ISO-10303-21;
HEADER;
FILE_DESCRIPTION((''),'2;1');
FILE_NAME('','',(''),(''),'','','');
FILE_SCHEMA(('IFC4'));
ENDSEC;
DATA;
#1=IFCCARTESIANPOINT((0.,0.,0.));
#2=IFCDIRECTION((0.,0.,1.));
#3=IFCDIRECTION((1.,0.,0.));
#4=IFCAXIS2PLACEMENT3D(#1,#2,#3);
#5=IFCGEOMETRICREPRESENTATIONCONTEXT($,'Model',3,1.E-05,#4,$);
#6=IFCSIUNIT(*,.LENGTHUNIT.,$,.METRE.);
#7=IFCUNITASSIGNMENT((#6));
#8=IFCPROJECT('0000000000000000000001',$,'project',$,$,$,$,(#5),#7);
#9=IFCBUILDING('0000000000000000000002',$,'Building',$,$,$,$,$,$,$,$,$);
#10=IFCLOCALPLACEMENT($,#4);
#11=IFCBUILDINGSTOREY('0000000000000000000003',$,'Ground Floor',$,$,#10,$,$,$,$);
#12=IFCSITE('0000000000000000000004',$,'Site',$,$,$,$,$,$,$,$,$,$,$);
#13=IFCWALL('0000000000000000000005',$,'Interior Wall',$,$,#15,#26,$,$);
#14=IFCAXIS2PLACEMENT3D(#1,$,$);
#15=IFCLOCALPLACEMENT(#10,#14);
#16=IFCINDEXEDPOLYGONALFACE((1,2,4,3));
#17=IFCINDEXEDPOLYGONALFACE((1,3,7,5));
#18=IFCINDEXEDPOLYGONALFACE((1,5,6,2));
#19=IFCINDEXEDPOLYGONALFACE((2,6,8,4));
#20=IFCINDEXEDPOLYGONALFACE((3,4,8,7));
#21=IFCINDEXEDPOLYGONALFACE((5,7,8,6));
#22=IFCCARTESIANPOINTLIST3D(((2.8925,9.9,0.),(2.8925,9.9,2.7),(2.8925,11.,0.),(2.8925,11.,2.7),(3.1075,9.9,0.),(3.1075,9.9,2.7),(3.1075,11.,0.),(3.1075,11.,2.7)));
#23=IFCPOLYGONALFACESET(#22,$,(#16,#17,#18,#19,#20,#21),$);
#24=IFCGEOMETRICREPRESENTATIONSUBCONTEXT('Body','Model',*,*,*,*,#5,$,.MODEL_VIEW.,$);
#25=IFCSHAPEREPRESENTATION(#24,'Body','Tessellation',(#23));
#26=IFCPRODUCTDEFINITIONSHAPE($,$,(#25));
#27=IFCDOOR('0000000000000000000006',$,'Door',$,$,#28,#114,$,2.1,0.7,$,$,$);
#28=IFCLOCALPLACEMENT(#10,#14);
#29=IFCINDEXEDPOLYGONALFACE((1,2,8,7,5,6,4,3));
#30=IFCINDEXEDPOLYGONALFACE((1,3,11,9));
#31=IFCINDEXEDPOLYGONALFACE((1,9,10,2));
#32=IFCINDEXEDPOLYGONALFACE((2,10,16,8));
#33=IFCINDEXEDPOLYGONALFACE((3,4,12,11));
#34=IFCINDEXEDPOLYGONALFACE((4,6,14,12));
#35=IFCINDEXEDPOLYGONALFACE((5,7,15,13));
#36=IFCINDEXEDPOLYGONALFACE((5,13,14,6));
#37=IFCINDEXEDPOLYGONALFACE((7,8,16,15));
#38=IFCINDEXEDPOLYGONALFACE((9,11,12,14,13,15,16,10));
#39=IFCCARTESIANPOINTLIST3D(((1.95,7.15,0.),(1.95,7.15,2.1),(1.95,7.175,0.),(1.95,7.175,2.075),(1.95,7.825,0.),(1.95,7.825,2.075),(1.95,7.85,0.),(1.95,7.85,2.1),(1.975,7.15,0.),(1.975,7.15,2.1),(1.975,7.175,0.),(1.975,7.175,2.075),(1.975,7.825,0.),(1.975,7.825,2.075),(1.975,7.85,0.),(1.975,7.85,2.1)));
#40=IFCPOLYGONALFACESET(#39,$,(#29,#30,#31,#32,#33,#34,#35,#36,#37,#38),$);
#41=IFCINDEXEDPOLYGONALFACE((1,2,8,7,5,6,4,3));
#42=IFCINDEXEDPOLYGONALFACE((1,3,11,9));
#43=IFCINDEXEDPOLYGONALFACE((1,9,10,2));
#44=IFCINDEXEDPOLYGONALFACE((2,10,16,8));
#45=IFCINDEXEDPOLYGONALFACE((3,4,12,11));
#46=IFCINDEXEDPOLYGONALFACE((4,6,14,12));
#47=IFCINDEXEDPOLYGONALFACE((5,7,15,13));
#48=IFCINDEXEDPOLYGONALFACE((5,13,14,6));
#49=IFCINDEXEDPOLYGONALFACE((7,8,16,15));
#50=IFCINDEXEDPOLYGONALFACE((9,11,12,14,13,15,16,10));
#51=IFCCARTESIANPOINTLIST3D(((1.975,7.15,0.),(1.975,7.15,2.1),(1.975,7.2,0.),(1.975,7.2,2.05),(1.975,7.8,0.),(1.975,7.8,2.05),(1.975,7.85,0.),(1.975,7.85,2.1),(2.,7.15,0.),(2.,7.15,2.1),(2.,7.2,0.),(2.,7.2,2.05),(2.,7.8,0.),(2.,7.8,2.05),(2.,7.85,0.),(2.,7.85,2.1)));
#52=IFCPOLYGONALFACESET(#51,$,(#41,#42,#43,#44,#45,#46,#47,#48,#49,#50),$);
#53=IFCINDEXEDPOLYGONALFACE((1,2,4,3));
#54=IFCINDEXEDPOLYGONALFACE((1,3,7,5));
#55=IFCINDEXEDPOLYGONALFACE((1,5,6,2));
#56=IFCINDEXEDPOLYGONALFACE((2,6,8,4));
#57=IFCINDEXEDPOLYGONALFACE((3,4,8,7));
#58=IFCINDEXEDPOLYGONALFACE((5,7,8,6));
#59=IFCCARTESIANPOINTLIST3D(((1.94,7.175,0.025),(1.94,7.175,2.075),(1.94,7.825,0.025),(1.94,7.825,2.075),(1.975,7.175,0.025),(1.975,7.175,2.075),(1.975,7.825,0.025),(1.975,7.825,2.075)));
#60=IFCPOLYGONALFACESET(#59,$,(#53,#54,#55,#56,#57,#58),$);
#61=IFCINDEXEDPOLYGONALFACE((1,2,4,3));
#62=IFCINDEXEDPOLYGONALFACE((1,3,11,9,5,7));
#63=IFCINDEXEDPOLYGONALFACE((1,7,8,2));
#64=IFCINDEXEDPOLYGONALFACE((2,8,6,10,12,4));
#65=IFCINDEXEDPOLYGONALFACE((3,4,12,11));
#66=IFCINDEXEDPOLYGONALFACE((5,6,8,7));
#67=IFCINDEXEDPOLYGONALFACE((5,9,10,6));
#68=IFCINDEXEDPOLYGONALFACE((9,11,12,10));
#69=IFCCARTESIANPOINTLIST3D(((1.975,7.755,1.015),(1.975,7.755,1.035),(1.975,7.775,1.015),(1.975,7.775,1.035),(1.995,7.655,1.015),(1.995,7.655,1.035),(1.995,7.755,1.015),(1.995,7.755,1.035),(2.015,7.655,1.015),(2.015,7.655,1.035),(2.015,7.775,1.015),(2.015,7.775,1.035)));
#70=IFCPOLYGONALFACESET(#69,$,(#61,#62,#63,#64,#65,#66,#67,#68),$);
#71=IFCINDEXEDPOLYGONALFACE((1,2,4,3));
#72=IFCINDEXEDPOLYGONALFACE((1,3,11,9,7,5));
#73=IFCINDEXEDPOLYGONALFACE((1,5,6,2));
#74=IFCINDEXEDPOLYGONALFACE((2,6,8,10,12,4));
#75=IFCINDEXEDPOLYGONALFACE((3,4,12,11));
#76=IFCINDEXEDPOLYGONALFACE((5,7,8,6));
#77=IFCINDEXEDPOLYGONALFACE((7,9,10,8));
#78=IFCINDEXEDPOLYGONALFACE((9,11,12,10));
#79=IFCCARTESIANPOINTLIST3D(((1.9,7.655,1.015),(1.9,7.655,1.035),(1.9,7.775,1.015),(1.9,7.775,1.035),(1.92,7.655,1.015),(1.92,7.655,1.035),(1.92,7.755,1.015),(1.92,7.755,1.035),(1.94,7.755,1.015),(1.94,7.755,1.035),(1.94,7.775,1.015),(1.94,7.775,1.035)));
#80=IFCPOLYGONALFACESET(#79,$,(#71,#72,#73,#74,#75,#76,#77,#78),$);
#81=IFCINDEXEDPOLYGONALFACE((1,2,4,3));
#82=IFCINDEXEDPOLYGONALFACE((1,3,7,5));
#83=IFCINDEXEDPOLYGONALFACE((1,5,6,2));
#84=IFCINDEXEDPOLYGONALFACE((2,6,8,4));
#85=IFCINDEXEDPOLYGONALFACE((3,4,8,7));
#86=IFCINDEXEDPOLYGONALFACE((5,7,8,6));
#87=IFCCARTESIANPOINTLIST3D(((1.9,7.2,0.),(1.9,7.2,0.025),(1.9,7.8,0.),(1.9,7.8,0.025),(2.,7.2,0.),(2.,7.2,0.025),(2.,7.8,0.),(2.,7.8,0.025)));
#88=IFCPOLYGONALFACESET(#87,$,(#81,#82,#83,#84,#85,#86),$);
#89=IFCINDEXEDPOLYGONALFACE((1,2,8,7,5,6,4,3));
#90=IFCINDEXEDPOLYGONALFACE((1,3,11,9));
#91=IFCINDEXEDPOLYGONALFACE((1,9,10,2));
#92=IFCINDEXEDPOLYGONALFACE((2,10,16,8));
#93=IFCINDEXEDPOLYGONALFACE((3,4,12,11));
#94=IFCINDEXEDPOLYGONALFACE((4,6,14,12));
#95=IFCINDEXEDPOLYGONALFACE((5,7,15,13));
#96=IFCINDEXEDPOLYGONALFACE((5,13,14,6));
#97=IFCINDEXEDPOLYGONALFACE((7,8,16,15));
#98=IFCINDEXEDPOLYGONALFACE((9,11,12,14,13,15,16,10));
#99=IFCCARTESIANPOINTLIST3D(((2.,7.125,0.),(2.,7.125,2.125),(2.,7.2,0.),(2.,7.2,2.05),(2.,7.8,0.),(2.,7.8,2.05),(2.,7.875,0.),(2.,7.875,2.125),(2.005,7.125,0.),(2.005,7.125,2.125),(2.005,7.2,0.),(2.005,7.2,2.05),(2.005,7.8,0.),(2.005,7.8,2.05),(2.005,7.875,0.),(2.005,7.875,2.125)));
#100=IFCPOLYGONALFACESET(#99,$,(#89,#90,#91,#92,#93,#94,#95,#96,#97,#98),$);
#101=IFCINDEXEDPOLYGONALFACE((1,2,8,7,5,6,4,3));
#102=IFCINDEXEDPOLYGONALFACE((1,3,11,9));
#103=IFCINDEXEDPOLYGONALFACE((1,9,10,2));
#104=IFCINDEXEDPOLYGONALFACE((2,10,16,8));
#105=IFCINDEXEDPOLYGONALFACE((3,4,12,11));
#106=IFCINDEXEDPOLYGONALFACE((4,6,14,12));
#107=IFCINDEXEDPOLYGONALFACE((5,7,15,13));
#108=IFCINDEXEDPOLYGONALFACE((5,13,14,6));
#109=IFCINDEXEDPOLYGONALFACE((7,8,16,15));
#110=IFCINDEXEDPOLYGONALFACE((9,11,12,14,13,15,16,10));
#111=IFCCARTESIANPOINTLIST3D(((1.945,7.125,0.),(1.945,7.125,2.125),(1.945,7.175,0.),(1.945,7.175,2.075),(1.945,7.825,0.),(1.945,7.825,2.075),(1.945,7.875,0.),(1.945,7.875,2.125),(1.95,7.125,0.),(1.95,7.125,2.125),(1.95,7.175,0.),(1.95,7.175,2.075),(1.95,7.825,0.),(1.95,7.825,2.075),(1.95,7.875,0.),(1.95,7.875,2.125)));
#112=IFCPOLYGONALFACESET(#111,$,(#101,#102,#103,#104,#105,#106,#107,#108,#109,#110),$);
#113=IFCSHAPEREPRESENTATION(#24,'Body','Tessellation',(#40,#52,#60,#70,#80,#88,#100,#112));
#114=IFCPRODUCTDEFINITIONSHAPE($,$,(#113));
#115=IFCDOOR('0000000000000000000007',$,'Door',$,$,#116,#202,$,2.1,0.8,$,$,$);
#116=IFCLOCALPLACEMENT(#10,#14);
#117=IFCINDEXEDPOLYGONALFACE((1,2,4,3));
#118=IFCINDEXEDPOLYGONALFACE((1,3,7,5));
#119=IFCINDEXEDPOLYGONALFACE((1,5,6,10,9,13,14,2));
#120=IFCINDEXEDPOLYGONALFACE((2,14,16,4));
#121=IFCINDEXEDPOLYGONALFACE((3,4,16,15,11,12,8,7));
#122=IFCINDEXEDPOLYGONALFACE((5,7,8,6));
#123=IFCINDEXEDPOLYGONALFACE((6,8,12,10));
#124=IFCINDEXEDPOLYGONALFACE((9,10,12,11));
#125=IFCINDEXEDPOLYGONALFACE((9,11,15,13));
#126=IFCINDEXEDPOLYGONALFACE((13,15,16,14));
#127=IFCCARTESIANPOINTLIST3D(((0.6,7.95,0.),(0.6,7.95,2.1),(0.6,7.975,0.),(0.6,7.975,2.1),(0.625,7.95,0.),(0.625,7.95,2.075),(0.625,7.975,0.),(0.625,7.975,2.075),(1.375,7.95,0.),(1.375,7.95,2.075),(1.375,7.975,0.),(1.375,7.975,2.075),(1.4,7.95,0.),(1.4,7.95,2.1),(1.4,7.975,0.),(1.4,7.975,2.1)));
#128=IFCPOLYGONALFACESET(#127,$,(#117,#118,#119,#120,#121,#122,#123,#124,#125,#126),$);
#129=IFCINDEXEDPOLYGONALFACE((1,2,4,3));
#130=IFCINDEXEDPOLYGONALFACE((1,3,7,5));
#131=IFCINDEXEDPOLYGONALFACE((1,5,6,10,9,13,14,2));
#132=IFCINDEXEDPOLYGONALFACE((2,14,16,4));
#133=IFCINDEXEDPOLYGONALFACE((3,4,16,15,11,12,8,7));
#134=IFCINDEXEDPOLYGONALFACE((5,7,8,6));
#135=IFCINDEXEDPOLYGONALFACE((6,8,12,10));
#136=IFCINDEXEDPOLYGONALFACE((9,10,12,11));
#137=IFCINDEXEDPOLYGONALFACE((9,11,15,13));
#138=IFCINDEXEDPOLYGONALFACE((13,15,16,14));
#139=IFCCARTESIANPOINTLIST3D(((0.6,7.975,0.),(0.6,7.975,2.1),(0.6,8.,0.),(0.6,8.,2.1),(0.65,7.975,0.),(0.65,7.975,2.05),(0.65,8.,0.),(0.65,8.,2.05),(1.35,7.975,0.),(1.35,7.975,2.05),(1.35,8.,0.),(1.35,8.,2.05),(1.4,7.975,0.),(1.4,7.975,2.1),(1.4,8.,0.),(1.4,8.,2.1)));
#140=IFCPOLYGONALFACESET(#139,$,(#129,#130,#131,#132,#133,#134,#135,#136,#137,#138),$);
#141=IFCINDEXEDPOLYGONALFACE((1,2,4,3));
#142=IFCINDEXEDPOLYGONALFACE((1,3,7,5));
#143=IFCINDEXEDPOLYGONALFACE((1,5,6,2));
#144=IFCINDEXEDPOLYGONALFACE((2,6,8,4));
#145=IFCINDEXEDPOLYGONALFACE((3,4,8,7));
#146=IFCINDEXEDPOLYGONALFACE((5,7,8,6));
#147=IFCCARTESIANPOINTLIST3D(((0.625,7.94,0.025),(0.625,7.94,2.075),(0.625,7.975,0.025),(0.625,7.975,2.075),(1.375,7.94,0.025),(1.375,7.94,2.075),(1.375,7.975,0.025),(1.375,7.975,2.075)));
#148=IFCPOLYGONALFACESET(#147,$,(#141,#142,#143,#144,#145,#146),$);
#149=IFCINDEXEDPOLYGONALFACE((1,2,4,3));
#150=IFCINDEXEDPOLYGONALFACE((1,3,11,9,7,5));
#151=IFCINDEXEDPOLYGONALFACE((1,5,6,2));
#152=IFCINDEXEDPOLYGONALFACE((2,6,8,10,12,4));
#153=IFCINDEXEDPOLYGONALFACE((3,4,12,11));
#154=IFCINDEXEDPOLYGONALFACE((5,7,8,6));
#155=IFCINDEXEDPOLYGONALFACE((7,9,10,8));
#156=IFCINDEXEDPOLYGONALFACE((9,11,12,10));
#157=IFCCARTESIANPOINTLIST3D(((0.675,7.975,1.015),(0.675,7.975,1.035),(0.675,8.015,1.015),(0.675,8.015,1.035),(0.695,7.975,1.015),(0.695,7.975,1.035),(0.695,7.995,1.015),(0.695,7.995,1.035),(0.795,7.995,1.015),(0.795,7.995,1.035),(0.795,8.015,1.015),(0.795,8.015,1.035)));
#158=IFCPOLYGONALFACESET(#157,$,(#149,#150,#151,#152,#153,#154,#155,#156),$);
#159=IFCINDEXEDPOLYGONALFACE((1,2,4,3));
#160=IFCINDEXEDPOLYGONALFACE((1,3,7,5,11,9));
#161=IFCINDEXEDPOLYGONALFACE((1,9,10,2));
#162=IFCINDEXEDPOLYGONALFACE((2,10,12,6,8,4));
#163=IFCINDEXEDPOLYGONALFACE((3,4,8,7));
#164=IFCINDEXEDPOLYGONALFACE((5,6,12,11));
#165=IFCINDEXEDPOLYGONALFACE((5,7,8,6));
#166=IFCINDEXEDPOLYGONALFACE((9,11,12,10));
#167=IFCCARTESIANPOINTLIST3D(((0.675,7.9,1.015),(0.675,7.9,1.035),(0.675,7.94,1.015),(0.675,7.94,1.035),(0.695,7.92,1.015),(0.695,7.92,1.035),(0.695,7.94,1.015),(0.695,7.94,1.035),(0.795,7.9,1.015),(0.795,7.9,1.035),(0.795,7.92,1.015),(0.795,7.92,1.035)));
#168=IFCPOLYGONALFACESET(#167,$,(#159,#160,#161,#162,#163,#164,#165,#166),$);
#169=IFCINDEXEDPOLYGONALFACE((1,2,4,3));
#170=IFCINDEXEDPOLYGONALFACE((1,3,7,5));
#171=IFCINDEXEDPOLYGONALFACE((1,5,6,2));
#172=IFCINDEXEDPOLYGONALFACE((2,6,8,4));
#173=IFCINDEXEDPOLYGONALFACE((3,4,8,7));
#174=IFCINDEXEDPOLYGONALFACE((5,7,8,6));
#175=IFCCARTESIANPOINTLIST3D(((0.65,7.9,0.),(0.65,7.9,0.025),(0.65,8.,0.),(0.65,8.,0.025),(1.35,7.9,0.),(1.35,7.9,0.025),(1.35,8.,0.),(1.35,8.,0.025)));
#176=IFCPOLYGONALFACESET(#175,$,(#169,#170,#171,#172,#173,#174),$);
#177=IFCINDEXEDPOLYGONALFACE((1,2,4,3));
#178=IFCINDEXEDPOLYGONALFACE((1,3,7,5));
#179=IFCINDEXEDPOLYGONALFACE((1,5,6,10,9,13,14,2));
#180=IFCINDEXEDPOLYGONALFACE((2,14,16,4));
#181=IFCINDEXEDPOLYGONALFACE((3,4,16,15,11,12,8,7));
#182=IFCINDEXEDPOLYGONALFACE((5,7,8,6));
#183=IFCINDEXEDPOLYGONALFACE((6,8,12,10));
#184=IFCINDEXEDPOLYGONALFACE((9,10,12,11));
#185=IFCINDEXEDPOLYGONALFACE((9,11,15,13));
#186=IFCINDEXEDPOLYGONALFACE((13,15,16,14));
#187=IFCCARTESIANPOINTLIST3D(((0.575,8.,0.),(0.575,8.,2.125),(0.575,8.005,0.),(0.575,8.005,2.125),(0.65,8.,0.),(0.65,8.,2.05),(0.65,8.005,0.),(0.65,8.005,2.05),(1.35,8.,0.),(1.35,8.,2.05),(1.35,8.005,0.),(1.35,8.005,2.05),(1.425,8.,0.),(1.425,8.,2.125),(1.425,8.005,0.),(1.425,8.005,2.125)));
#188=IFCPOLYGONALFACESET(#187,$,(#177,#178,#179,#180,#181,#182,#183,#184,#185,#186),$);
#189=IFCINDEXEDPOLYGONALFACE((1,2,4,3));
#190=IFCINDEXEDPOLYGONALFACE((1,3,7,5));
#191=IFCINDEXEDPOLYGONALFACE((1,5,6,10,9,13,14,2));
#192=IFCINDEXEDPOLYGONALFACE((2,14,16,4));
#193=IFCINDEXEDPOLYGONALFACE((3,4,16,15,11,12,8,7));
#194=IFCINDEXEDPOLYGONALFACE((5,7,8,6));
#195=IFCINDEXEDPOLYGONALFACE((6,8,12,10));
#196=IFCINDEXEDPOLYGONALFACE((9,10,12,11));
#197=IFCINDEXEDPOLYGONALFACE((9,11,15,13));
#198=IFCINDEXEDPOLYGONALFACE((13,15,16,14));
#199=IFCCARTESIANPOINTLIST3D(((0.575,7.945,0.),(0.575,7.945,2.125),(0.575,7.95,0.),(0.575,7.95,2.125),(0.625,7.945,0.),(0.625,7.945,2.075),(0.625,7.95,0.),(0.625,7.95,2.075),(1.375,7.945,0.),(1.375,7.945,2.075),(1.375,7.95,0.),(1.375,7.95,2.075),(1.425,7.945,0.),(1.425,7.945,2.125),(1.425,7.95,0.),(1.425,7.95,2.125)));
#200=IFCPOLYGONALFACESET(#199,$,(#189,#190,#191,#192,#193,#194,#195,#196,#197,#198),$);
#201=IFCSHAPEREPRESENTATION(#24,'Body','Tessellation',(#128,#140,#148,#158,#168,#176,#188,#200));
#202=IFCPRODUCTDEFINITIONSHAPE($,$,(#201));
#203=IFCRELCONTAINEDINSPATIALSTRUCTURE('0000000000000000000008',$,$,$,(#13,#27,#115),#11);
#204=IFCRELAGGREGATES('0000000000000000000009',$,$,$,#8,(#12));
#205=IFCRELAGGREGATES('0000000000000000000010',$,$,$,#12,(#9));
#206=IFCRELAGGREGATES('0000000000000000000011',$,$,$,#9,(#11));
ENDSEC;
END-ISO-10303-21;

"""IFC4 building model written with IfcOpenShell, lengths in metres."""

from ifc_helpers import new_model, si_unit, frame, origin_with_axes, place, context, subcontext, project, spatial, line, indexed_curve, outline, extrude, element, save


model = new_model("IFC4")

# Units and contexts
model_context = context("Model", 3, precision=1e-05, world=origin_with_axes())
body_context = subcontext(model_context, "Body", "Model", "MODEL_VIEW")
ifc_project = project(units=[si_unit("LENGTHUNIT", "METRE")], contexts=[model_context])

# Site, building, storey
site = spatial("IfcSite", under=ifc_project, Name="Site")
building = spatial("IfcBuilding", under=site, Name="Building")
storey_placement = place(None, origin_with_axes())
storey = spatial("IfcBuildingStorey", under=building, at=storey_placement, Name="Ground Floor")

# Wall
for number, where, z_axis, x_axis, name in (
    (1, (3.0, 9.9, 0.0), (0.0, 0.0, 1.0), (0.0, 1.0, 0.0), "Interior Wall"),
):
    element("IfcWall", number, at=place(storey_placement, frame(where, z_axis=z_axis, x_axis=x_axis)), inside=storey, Name=name, context=body_context, shape_type="SweptSolid", body=[
        extrude(outline(indexed_curve([(0.0, 0.0), (0.0, 0.215), (1.1, 0.215), (1.1, 0.0), (0.0, 0.0)], self_intersect=False)), frame((0.0, -0.1075, 0.0), z_axis=(0.0, 0.0, 1.0), x_axis=(1.0, 0.0, 0.0)), (0.0, 0.0, 1.0), 2.7),
    ])

# Doors
door_1_placement = place(storey_placement, frame((2.0, 7.15, 0.0), z_axis=(0.0, 0.0, 1.0), x_axis=(0.0, 1.0, 0.0)))
element("IfcDoor", 2, at=door_1_placement, inside=storey, Name="Door", OverallHeight=2.1, OverallWidth=0.7, context=body_context, shape_type="SweptSolid", body=[
    extrude(outline(indexed_curve([(0.0, 0.0), (0.0, 2.1), (0.7, 2.1), (0.7, 0.0), (0.675, 0.0), (0.675, 2.075), (0.025, 2.075), (0.025, 0.0)], segments=[line(1, 2, 3, 4, 5, 6, 7, 8, 1)])), frame((0.0, 0.025, 0.0), z_axis=(0.0, -1.0, 0.0), x_axis=(1.0, 0.0, 0.0)), (0.0, 0.0, -1.0), 0.025),
    extrude(outline(indexed_curve([(0.0, 0.0), (0.0, 2.1), (0.7, 2.1), (0.7, 0.0), (0.65, 0.0), (0.65, 2.05), (0.05, 2.05), (0.05, 0.0)], segments=[line(1, 2, 3, 4, 5, 6, 7, 8, 1)])), frame((0.0, 0.0, 0.0), z_axis=(0.0, -1.0, 0.0), x_axis=(1.0, 0.0, 0.0)), (0.0, 0.0, -1.0), 0.025),
    extrude(outline(indexed_curve([(0.0, 0.0), (0.65, 0.0), (0.65, 0.035), (0.0, 0.035)], segments=[line(1, 2, 3, 4, 1)])), frame((0.025, 0.025, 0.025), z_axis=(0.0, 0.0, 1.0), x_axis=(1.0, 0.0, 0.0)), (0.0, 0.0, 1.0), 2.05),
    extrude(outline(indexed_curve([(0.0, 0.0), (0.0, -0.04), (-0.12, -0.04), (-0.12, -0.02), (-0.02, -0.02), (-0.02, 0.0)], segments=[line(1, 2, 3, 4, 5, 6, 1)])), frame((0.625, 0.025, 1.015), z_axis=(0.0, 0.0, 1.0), x_axis=(1.0, 0.0, 0.0)), (0.0, 0.0, 1.0), 0.02),
    extrude(outline(indexed_curve([(0.0, 0.0), (0.0, 0.04), (-0.12, 0.04), (-0.12, 0.02), (-0.02, 0.02), (-0.02, 0.0)], segments=[line(1, 2, 3, 4, 5, 6, 1)])), frame((0.625, 0.06, 1.015), z_axis=(0.0, 0.0, 1.0), x_axis=(1.0, 0.0, 0.0)), (0.0, 0.0, 1.0), 0.02),
    extrude(outline(indexed_curve([(0.0, 0.0), (0.6, 0.0), (0.6, 0.1), (0.0, 0.1)], segments=[line(1, 2, 3, 4, 1)])), frame((0.05, 0.0, 0.0), z_axis=(0.0, 0.0, 1.0), x_axis=(1.0, 0.0, 0.0)), (0.0, 0.0, 1.0), 0.025),
    extrude(outline(indexed_curve([(0.0, 0.0), (0.0, 2.125), (0.75, 2.125), (0.75, 0.0), (0.675, 0.0), (0.675, 2.05), (0.075, 2.05), (0.075, 0.0)], segments=[line(1, 2, 3, 4, 5, 6, 7, 8, 1)])), frame((-0.025, -0.005, 0.0), z_axis=(0.0, -1.0, 0.0), x_axis=(1.0, 0.0, 0.0)), (0.0, 0.0, -1.0), 0.005),
    extrude(outline(indexed_curve([(0.0, 0.0), (0.0, 2.125), (0.75, 2.125), (0.75, 0.0), (0.7, 0.0), (0.7, 2.075), (0.05, 2.075), (0.05, 0.0)], segments=[line(1, 2, 3, 4, 5, 6, 7, 8, 1)])), frame((-0.025, 0.05, 0.0), z_axis=(0.0, -1.0, 0.0), x_axis=(1.0, 0.0, 0.0)), (0.0, 0.0, -1.0), 0.005),
])
door_2_placement = place(storey_placement, frame((1.4, 8.0, 0.0), z_axis=(0.0, 0.0, 1.0), x_axis=(-1.0, 0.0, 0.0)))
element("IfcDoor", 3, at=door_2_placement, inside=storey, Name="Door", OverallHeight=2.1, OverallWidth=0.8, context=body_context, shape_type="SweptSolid", body=[
    extrude(outline(indexed_curve([(0.0, 0.0), (0.0, 2.1), (0.8, 2.1), (0.8, 0.0), (0.775, 0.0), (0.775, 2.075), (0.025, 2.075), (0.025, 0.0)], segments=[line(1, 2, 3, 4, 5, 6, 7, 8, 1)])), frame((0.0, 0.025, 0.0), z_axis=(0.0, -1.0, 0.0), x_axis=(1.0, 0.0, 0.0)), (0.0, 0.0, -1.0), 0.025),
    extrude(outline(indexed_curve([(0.0, 0.0), (0.0, 2.1), (0.8, 2.1), (0.8, 0.0), (0.75, 0.0), (0.75, 2.05), (0.05, 2.05), (0.05, 0.0)], segments=[line(1, 2, 3, 4, 5, 6, 7, 8, 1)])), frame((0.0, 0.0, 0.0), z_axis=(0.0, -1.0, 0.0), x_axis=(1.0, 0.0, 0.0)), (0.0, 0.0, -1.0), 0.025),
    extrude(outline(indexed_curve([(0.0, 0.0), (0.75, 0.0), (0.75, 0.035), (0.0, 0.035)], segments=[line(1, 2, 3, 4, 1)])), frame((0.025, 0.025, 0.025), z_axis=(0.0, 0.0, 1.0), x_axis=(1.0, 0.0, 0.0)), (0.0, 0.0, 1.0), 2.05),
    extrude(outline(indexed_curve([(0.0, 0.0), (0.0, -0.04), (-0.12, -0.04), (-0.12, -0.02), (-0.02, -0.02), (-0.02, 0.0)], segments=[line(1, 2, 3, 4, 5, 6, 1)])), frame((0.725, 0.025, 1.015), z_axis=(0.0, 0.0, 1.0), x_axis=(1.0, 0.0, 0.0)), (0.0, 0.0, 1.0), 0.02),
    extrude(outline(indexed_curve([(0.0, 0.0), (0.0, 0.04), (-0.12, 0.04), (-0.12, 0.02), (-0.02, 0.02), (-0.02, 0.0)], segments=[line(1, 2, 3, 4, 5, 6, 1)])), frame((0.725, 0.06, 1.015), z_axis=(0.0, 0.0, 1.0), x_axis=(1.0, 0.0, 0.0)), (0.0, 0.0, 1.0), 0.02),
    extrude(outline(indexed_curve([(0.0, 0.0), (0.7, 0.0), (0.7, 0.1), (0.0, 0.1)], segments=[line(1, 2, 3, 4, 1)])), frame((0.05, 0.0, 0.0), z_axis=(0.0, 0.0, 1.0), x_axis=(1.0, 0.0, 0.0)), (0.0, 0.0, 1.0), 0.025),
    extrude(outline(indexed_curve([(0.0, 0.0), (0.0, 2.125), (0.85, 2.125), (0.85, 0.0), (0.775, 0.0), (0.775, 2.05), (0.075, 2.05), (0.075, 0.0)], segments=[line(1, 2, 3, 4, 5, 6, 7, 8, 1)])), frame((-0.025, -0.005, 0.0), z_axis=(0.0, -1.0, 0.0), x_axis=(1.0, 0.0, 0.0)), (0.0, 0.0, -1.0), 0.005),
    extrude(outline(indexed_curve([(0.0, 0.0), (0.0, 2.125), (0.85, 2.125), (0.85, 0.0), (0.8, 0.0), (0.8, 2.075), (0.05, 2.075), (0.05, 0.0)], segments=[line(1, 2, 3, 4, 5, 6, 7, 8, 1)])), frame((-0.025, 0.05, 0.0), z_axis=(0.0, -1.0, 0.0), x_axis=(1.0, 0.0, 0.0)), (0.0, 0.0, -1.0), 0.005),
])

save(model, "model.ifc")
